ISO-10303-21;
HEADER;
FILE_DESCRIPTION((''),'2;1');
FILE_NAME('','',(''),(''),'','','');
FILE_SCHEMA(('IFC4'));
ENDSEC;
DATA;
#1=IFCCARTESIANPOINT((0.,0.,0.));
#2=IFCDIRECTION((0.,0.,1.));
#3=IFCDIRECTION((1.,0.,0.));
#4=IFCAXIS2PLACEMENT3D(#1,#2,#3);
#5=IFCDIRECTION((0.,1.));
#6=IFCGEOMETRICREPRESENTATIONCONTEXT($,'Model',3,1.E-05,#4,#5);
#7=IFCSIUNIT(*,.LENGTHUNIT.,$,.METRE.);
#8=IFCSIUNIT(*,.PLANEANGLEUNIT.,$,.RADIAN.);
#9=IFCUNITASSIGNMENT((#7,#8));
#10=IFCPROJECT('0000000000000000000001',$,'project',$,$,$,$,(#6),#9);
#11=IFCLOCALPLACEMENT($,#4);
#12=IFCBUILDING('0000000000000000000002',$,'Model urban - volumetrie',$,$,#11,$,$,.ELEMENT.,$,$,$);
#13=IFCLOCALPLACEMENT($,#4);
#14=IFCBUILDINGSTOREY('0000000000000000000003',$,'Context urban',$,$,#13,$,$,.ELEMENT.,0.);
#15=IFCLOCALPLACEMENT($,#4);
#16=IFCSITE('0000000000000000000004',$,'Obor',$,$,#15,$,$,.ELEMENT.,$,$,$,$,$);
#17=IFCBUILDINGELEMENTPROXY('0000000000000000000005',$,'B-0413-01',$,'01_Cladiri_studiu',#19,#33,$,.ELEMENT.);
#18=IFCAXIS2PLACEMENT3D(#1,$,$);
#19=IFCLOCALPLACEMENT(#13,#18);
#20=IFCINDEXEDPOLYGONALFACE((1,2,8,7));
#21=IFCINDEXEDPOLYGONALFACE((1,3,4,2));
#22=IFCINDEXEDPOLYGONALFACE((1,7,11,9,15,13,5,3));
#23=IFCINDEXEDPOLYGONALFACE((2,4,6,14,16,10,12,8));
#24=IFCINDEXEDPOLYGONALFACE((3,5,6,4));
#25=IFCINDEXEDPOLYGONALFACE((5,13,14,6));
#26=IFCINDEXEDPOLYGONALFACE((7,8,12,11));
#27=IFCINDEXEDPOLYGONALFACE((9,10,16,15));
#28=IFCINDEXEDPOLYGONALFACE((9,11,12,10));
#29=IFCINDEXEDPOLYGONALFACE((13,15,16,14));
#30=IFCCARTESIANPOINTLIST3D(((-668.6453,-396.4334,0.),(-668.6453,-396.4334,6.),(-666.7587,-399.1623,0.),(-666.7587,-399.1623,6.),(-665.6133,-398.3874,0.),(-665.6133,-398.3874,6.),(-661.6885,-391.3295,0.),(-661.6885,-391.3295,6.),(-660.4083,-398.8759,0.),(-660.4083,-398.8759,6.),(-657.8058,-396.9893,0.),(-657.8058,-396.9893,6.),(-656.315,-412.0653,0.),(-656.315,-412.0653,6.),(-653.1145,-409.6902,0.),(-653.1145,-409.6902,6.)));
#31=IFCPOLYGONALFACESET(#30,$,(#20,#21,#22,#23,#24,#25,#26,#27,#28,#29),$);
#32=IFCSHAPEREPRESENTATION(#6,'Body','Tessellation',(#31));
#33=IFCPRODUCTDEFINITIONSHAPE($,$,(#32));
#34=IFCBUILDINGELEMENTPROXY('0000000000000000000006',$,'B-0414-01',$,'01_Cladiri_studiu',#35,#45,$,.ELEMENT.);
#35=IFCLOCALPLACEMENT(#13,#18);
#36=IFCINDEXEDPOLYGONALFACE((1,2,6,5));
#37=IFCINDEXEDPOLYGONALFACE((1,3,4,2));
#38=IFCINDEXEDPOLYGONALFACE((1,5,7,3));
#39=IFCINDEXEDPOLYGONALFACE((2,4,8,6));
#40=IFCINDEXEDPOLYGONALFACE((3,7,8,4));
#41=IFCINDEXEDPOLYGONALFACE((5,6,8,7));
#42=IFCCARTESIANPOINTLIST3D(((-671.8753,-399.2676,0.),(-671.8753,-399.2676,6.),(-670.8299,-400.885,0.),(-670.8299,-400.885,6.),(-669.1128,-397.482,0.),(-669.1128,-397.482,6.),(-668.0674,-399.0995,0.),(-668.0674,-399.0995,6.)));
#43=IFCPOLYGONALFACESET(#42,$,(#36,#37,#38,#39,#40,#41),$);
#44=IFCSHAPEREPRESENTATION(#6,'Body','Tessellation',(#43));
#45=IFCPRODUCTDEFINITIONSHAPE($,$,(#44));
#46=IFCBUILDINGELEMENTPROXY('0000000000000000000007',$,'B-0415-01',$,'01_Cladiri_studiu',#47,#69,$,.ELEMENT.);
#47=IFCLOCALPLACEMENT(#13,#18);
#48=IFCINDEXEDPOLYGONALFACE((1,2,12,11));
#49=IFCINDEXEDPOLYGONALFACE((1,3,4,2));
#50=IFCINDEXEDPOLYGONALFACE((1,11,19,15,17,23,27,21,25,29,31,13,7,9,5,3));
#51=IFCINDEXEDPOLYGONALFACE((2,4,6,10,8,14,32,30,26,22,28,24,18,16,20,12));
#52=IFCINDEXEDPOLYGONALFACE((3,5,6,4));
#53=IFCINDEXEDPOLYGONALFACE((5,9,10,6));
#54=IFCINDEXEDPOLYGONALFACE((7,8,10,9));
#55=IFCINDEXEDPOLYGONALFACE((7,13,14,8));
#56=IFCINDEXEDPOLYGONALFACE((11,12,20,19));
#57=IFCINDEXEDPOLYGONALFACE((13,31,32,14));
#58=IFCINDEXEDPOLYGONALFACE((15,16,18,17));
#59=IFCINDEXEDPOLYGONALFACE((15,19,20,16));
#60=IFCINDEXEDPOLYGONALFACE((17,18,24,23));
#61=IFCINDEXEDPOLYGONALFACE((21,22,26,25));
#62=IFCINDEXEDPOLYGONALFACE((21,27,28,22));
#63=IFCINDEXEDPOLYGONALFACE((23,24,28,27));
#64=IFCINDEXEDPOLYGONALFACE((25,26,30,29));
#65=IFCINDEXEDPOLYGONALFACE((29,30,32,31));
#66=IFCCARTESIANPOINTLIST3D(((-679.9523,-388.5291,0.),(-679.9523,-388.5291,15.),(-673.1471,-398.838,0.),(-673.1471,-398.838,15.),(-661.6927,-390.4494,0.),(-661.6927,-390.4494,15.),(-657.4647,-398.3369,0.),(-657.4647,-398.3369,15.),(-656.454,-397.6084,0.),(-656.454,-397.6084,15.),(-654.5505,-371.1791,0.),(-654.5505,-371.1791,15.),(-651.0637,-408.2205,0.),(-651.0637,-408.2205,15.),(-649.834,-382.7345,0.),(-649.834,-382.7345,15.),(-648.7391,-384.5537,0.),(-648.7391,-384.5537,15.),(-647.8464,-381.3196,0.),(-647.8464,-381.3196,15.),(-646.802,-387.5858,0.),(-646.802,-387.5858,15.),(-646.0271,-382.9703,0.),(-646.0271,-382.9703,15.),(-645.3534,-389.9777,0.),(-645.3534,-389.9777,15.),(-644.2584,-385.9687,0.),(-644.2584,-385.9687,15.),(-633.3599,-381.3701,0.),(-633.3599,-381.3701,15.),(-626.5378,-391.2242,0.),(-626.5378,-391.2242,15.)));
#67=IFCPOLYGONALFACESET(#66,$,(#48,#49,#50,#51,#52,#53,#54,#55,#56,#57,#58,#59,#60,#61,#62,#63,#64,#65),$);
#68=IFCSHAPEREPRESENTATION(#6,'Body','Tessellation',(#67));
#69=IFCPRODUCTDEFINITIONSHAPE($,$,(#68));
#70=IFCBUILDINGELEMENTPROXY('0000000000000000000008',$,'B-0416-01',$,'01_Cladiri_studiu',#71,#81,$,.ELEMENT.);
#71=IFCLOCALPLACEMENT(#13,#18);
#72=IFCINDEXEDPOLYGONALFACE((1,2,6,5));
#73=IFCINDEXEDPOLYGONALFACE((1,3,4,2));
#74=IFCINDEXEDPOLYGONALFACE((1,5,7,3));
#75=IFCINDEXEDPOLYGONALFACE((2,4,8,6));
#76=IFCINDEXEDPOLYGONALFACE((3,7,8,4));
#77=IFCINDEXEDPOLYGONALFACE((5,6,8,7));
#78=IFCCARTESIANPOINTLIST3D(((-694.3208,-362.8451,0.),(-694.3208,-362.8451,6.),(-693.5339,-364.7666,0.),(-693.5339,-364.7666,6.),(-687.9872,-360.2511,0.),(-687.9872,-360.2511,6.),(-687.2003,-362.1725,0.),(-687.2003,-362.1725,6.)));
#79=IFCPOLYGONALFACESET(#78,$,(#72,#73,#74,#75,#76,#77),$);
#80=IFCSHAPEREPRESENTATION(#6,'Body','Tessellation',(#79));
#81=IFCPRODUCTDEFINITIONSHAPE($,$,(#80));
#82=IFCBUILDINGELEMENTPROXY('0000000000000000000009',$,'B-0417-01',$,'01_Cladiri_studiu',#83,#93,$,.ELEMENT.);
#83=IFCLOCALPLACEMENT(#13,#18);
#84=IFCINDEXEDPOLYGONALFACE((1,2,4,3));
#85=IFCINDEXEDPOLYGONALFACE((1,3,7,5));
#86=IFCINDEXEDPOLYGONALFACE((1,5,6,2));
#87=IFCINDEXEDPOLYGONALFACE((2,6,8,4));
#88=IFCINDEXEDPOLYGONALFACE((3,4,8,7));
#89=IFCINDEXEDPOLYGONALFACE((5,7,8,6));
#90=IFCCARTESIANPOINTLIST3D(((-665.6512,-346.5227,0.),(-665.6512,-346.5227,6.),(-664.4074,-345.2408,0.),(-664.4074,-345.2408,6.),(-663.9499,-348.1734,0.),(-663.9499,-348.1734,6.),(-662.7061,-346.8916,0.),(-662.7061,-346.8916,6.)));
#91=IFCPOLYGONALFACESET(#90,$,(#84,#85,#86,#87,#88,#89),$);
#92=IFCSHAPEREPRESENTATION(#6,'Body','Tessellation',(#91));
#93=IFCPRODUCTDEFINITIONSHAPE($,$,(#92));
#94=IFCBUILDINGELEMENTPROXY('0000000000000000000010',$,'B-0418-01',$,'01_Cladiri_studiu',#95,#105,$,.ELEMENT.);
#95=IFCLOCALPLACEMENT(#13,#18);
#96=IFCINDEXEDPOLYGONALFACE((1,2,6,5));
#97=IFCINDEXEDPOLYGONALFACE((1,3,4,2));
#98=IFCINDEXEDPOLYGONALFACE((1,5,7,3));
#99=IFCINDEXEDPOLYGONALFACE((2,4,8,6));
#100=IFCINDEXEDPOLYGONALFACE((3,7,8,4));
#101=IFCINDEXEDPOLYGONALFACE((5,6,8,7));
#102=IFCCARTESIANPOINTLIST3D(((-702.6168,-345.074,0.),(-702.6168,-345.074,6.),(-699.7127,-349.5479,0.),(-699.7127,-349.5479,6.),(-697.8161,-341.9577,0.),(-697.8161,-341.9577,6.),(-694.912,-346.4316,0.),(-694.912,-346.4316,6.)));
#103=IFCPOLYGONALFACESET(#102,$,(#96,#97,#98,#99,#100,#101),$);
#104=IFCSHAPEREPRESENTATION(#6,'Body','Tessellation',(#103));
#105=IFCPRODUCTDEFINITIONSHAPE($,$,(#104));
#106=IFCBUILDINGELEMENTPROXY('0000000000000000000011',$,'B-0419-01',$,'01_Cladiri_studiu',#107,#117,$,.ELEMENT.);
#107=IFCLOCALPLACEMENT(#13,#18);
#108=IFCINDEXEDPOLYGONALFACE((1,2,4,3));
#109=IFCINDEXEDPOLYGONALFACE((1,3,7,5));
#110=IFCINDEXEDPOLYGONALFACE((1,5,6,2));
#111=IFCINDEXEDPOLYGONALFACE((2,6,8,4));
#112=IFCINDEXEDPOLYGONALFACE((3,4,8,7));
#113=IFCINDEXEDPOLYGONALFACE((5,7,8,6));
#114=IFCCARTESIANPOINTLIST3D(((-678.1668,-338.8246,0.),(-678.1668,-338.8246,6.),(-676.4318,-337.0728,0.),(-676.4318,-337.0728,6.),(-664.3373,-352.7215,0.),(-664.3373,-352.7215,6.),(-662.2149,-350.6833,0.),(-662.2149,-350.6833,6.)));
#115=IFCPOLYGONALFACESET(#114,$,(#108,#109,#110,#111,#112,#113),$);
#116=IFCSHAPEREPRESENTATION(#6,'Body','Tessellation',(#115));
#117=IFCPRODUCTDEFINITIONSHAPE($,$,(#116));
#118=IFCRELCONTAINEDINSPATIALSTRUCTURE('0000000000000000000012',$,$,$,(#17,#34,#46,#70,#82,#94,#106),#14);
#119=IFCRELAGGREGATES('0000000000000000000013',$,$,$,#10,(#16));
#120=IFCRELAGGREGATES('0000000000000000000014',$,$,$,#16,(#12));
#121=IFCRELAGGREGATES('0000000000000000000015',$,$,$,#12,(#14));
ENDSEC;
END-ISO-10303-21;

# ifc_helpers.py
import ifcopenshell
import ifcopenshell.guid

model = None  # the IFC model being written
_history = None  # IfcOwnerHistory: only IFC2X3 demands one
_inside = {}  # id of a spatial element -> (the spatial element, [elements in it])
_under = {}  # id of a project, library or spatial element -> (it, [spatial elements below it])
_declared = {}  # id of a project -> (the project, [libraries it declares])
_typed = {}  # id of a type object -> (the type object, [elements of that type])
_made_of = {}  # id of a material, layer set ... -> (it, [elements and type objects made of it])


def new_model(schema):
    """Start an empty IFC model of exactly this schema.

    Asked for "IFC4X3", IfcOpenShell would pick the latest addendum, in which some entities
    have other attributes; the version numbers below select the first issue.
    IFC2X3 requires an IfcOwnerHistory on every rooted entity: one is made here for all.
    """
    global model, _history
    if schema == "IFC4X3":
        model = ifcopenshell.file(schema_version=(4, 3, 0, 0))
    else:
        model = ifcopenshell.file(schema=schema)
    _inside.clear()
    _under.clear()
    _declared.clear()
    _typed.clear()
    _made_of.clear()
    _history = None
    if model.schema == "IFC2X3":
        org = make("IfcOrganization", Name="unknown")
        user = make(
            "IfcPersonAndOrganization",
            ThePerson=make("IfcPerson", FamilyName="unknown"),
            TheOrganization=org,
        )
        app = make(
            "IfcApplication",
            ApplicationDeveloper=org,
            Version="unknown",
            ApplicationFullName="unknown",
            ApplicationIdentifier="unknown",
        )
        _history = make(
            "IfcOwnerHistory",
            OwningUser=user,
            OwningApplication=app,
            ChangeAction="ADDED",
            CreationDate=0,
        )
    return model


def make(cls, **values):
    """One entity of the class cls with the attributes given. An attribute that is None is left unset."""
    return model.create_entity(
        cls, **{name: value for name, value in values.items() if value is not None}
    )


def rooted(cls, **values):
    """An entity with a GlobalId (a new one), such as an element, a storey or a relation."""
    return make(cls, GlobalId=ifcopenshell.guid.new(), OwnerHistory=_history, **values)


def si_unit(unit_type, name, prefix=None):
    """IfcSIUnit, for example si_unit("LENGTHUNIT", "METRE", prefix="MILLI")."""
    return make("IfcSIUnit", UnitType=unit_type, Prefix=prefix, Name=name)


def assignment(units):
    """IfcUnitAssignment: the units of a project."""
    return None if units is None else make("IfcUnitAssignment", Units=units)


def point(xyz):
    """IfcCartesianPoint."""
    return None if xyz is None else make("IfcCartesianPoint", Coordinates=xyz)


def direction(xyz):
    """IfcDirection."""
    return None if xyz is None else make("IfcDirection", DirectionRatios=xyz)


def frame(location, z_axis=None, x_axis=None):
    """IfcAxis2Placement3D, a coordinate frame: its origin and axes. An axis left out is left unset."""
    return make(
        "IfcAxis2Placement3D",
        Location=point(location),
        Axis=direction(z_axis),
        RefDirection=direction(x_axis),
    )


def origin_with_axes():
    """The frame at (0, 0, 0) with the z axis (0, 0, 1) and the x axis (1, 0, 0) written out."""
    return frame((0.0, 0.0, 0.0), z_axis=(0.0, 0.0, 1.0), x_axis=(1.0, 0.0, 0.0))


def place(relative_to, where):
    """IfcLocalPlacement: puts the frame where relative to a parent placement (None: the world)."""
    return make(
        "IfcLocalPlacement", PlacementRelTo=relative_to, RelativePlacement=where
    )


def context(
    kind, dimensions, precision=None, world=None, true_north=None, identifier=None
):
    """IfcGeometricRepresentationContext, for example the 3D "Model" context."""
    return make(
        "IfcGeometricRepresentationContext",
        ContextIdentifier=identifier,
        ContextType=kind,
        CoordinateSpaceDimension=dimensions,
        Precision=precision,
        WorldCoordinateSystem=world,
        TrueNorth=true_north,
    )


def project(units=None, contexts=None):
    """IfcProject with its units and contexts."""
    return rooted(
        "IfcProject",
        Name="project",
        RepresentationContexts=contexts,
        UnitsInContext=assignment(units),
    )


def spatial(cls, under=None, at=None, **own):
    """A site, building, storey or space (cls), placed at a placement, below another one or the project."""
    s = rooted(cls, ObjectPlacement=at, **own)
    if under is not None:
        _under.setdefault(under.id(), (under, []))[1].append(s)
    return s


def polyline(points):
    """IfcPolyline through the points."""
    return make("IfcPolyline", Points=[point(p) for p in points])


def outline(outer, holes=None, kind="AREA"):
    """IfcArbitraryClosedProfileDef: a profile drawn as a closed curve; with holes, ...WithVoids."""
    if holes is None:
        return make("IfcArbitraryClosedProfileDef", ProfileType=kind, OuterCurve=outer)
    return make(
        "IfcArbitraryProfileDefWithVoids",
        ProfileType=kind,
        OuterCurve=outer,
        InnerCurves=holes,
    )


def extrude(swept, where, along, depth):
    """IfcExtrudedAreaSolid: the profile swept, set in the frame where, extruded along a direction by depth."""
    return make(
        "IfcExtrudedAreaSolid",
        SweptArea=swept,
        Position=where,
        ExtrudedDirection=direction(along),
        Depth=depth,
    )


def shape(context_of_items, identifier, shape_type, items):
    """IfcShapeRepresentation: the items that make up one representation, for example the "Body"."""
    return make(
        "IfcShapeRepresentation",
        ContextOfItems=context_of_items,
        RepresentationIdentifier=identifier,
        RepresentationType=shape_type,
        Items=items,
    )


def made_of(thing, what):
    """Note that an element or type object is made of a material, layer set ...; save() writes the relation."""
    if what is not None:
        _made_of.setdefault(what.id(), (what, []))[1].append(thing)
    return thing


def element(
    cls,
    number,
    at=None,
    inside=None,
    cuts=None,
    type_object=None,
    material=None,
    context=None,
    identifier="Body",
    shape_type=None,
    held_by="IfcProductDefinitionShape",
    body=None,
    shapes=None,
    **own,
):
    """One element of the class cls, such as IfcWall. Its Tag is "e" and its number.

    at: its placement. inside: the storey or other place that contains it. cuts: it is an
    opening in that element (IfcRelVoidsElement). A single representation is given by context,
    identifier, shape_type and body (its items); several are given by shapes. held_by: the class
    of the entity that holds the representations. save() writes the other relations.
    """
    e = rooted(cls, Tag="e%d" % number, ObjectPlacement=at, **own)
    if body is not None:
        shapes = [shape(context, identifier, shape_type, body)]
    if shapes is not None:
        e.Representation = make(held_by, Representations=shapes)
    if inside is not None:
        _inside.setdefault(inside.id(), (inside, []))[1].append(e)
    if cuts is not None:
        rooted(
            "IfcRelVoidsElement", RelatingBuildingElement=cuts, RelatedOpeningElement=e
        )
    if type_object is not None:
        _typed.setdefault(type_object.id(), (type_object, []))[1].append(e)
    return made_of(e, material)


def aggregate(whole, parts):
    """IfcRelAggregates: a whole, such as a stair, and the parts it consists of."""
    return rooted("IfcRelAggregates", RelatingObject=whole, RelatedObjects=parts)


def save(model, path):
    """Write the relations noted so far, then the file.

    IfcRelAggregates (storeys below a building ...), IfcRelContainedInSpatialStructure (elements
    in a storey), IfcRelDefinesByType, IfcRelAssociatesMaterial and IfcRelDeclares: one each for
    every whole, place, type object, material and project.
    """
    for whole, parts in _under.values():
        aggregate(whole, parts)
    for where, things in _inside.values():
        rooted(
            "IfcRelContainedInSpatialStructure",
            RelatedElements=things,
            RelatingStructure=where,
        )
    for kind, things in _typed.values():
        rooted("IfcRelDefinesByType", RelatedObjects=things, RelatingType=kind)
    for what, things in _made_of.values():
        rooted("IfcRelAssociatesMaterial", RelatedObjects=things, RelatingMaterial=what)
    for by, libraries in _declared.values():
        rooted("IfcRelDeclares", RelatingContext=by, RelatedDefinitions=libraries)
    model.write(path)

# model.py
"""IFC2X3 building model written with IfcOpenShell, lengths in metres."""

from ifc_helpers import new_model, si_unit, direction, origin_with_axes, place, context, project, spatial, polyline, outline, extrude, element, save


model = new_model("IFC2X3")

# Units and contexts
model_context = context("Model", 3, precision=1e-05, world=origin_with_axes(), true_north=direction((0.0, 1.0)))
ifc_project = project(units=[si_unit("LENGTHUNIT", "METRE"), si_unit("PLANEANGLEUNIT", "RADIAN")], contexts=[model_context])

# Site, building, storey
site_placement = place(None, origin_with_axes())
site = spatial("IfcSite", under=ifc_project, at=site_placement, Name="Obor", CompositionType="ELEMENT")
building_placement = place(None, origin_with_axes())
building = spatial("IfcBuilding", under=site, at=building_placement, Name="Model urban - volumetrie", CompositionType="ELEMENT")
storey_placement = place(None, origin_with_axes())
storey = spatial("IfcBuildingStorey", under=building, at=storey_placement, Name="Context urban", CompositionType="ELEMENT", Elevation=0.0)

# Building element proxies
proxy_1_placement = place(None, origin_with_axes())
element("IfcBuildingElementProxy", 1, at=proxy_1_placement, inside=storey, Name="B-0413-01", ObjectType="01_Cladiri_studiu", CompositionType="ELEMENT", context=model_context, shape_type="SweptSolid", body=[
    extrude(outline(polyline([(-660.4083, -398.8759), (-657.8058, -396.9893), (-661.6885, -391.3295), (-668.6453, -396.4334), (-666.7587, -399.1623), (-665.6133, -398.3874), (-656.315, -412.0653), (-653.1145, -409.6902), (-660.4083, -398.8759)])), origin_with_axes(), (0.0, 0.0, 1.0), 6.0),
])
proxy_2_placement = place(None, origin_with_axes())
element("IfcBuildingElementProxy", 2, at=proxy_2_placement, inside=storey, Name="B-0414-01", ObjectType="01_Cladiri_studiu", CompositionType="ELEMENT", context=model_context, shape_type="SweptSolid", body=[
    extrude(outline(polyline([(-668.0674, -399.0995), (-669.1128, -397.482), (-671.8753, -399.2676), (-670.8299, -400.885), (-668.0674, -399.0995)])), origin_with_axes(), (0.0, 0.0, 1.0), 6.0),
])
proxy_3_placement = place(None, origin_with_axes())
element("IfcBuildingElementProxy", 3, at=proxy_3_placement, inside=storey, Name="B-0415-01", ObjectType="01_Cladiri_studiu", CompositionType="ELEMENT", context=model_context, shape_type="SweptSolid", body=[
    extrude(outline(polyline([(-661.6927, -390.4494), (-656.454, -397.6084), (-657.4647, -398.3369), (-651.0637, -408.2205), (-626.5378, -391.2242), (-633.3599, -381.3701), (-645.3534, -389.9777), (-646.802, -387.5858), (-644.2584, -385.9687), (-646.0271, -382.9703), (-648.7391, -384.5537), (-649.834, -382.7345), (-647.8464, -381.3196), (-654.5505, -371.1791), (-679.9523, -388.5291), (-673.1471, -398.838), (-661.6927, -390.4494)])), origin_with_axes(), (0.0, 0.0, 1.0), 15.0),
])
proxy_4_placement = place(None, origin_with_axes())
element("IfcBuildingElementProxy", 4, at=proxy_4_placement, inside=storey, Name="B-0416-01", ObjectType="01_Cladiri_studiu", CompositionType="ELEMENT", context=model_context, shape_type="SweptSolid", body=[
    extrude(outline(polyline([(-693.5339, -364.7666), (-687.2003, -362.1725), (-687.9872, -360.2511), (-694.3208, -362.8451), (-693.5339, -364.7666)])), origin_with_axes(), (0.0, 0.0, 1.0), 6.0),
])
proxy_5_placement = place(None, origin_with_axes())
element("IfcBuildingElementProxy", 5, at=proxy_5_placement, inside=storey, Name="B-0417-01", ObjectType="01_Cladiri_studiu", CompositionType="ELEMENT", context=model_context, shape_type="SweptSolid", body=[
    extrude(outline(polyline([(-663.9499, -348.1734), (-662.7061, -346.8916), (-664.4074, -345.2408), (-665.6512, -346.5227), (-663.9499, -348.1734)])), origin_with_axes(), (0.0, 0.0, 1.0), 6.0),
])
proxy_6_placement = place(None, origin_with_axes())
element("IfcBuildingElementProxy", 6, at=proxy_6_placement, inside=storey, Name="B-0418-01", ObjectType="01_Cladiri_studiu", CompositionType="ELEMENT", context=model_context, shape_type="SweptSolid", body=[
    extrude(outline(polyline([(-694.912, -346.4316), (-697.8161, -341.9577), (-702.6168, -345.074), (-699.7127, -349.5479), (-694.912, -346.4316)])), origin_with_axes(), (0.0, 0.0, 1.0), 6.0),
])
proxy_7_placement = place(None, origin_with_axes())
element("IfcBuildingElementProxy", 7, at=proxy_7_placement, inside=storey, Name="B-0419-01", ObjectType="01_Cladiri_studiu", CompositionType="ELEMENT", context=model_context, shape_type="SweptSolid", body=[
    extrude(outline(polyline([(-662.2149, -350.6833), (-676.4318, -337.0728), (-678.1668, -338.8246), (-664.3373, -352.7215), (-662.2149, -350.6833)])), origin_with_axes(), (0.0, 0.0, 1.0), 6.0),
])

save(model, "model.ifc")
